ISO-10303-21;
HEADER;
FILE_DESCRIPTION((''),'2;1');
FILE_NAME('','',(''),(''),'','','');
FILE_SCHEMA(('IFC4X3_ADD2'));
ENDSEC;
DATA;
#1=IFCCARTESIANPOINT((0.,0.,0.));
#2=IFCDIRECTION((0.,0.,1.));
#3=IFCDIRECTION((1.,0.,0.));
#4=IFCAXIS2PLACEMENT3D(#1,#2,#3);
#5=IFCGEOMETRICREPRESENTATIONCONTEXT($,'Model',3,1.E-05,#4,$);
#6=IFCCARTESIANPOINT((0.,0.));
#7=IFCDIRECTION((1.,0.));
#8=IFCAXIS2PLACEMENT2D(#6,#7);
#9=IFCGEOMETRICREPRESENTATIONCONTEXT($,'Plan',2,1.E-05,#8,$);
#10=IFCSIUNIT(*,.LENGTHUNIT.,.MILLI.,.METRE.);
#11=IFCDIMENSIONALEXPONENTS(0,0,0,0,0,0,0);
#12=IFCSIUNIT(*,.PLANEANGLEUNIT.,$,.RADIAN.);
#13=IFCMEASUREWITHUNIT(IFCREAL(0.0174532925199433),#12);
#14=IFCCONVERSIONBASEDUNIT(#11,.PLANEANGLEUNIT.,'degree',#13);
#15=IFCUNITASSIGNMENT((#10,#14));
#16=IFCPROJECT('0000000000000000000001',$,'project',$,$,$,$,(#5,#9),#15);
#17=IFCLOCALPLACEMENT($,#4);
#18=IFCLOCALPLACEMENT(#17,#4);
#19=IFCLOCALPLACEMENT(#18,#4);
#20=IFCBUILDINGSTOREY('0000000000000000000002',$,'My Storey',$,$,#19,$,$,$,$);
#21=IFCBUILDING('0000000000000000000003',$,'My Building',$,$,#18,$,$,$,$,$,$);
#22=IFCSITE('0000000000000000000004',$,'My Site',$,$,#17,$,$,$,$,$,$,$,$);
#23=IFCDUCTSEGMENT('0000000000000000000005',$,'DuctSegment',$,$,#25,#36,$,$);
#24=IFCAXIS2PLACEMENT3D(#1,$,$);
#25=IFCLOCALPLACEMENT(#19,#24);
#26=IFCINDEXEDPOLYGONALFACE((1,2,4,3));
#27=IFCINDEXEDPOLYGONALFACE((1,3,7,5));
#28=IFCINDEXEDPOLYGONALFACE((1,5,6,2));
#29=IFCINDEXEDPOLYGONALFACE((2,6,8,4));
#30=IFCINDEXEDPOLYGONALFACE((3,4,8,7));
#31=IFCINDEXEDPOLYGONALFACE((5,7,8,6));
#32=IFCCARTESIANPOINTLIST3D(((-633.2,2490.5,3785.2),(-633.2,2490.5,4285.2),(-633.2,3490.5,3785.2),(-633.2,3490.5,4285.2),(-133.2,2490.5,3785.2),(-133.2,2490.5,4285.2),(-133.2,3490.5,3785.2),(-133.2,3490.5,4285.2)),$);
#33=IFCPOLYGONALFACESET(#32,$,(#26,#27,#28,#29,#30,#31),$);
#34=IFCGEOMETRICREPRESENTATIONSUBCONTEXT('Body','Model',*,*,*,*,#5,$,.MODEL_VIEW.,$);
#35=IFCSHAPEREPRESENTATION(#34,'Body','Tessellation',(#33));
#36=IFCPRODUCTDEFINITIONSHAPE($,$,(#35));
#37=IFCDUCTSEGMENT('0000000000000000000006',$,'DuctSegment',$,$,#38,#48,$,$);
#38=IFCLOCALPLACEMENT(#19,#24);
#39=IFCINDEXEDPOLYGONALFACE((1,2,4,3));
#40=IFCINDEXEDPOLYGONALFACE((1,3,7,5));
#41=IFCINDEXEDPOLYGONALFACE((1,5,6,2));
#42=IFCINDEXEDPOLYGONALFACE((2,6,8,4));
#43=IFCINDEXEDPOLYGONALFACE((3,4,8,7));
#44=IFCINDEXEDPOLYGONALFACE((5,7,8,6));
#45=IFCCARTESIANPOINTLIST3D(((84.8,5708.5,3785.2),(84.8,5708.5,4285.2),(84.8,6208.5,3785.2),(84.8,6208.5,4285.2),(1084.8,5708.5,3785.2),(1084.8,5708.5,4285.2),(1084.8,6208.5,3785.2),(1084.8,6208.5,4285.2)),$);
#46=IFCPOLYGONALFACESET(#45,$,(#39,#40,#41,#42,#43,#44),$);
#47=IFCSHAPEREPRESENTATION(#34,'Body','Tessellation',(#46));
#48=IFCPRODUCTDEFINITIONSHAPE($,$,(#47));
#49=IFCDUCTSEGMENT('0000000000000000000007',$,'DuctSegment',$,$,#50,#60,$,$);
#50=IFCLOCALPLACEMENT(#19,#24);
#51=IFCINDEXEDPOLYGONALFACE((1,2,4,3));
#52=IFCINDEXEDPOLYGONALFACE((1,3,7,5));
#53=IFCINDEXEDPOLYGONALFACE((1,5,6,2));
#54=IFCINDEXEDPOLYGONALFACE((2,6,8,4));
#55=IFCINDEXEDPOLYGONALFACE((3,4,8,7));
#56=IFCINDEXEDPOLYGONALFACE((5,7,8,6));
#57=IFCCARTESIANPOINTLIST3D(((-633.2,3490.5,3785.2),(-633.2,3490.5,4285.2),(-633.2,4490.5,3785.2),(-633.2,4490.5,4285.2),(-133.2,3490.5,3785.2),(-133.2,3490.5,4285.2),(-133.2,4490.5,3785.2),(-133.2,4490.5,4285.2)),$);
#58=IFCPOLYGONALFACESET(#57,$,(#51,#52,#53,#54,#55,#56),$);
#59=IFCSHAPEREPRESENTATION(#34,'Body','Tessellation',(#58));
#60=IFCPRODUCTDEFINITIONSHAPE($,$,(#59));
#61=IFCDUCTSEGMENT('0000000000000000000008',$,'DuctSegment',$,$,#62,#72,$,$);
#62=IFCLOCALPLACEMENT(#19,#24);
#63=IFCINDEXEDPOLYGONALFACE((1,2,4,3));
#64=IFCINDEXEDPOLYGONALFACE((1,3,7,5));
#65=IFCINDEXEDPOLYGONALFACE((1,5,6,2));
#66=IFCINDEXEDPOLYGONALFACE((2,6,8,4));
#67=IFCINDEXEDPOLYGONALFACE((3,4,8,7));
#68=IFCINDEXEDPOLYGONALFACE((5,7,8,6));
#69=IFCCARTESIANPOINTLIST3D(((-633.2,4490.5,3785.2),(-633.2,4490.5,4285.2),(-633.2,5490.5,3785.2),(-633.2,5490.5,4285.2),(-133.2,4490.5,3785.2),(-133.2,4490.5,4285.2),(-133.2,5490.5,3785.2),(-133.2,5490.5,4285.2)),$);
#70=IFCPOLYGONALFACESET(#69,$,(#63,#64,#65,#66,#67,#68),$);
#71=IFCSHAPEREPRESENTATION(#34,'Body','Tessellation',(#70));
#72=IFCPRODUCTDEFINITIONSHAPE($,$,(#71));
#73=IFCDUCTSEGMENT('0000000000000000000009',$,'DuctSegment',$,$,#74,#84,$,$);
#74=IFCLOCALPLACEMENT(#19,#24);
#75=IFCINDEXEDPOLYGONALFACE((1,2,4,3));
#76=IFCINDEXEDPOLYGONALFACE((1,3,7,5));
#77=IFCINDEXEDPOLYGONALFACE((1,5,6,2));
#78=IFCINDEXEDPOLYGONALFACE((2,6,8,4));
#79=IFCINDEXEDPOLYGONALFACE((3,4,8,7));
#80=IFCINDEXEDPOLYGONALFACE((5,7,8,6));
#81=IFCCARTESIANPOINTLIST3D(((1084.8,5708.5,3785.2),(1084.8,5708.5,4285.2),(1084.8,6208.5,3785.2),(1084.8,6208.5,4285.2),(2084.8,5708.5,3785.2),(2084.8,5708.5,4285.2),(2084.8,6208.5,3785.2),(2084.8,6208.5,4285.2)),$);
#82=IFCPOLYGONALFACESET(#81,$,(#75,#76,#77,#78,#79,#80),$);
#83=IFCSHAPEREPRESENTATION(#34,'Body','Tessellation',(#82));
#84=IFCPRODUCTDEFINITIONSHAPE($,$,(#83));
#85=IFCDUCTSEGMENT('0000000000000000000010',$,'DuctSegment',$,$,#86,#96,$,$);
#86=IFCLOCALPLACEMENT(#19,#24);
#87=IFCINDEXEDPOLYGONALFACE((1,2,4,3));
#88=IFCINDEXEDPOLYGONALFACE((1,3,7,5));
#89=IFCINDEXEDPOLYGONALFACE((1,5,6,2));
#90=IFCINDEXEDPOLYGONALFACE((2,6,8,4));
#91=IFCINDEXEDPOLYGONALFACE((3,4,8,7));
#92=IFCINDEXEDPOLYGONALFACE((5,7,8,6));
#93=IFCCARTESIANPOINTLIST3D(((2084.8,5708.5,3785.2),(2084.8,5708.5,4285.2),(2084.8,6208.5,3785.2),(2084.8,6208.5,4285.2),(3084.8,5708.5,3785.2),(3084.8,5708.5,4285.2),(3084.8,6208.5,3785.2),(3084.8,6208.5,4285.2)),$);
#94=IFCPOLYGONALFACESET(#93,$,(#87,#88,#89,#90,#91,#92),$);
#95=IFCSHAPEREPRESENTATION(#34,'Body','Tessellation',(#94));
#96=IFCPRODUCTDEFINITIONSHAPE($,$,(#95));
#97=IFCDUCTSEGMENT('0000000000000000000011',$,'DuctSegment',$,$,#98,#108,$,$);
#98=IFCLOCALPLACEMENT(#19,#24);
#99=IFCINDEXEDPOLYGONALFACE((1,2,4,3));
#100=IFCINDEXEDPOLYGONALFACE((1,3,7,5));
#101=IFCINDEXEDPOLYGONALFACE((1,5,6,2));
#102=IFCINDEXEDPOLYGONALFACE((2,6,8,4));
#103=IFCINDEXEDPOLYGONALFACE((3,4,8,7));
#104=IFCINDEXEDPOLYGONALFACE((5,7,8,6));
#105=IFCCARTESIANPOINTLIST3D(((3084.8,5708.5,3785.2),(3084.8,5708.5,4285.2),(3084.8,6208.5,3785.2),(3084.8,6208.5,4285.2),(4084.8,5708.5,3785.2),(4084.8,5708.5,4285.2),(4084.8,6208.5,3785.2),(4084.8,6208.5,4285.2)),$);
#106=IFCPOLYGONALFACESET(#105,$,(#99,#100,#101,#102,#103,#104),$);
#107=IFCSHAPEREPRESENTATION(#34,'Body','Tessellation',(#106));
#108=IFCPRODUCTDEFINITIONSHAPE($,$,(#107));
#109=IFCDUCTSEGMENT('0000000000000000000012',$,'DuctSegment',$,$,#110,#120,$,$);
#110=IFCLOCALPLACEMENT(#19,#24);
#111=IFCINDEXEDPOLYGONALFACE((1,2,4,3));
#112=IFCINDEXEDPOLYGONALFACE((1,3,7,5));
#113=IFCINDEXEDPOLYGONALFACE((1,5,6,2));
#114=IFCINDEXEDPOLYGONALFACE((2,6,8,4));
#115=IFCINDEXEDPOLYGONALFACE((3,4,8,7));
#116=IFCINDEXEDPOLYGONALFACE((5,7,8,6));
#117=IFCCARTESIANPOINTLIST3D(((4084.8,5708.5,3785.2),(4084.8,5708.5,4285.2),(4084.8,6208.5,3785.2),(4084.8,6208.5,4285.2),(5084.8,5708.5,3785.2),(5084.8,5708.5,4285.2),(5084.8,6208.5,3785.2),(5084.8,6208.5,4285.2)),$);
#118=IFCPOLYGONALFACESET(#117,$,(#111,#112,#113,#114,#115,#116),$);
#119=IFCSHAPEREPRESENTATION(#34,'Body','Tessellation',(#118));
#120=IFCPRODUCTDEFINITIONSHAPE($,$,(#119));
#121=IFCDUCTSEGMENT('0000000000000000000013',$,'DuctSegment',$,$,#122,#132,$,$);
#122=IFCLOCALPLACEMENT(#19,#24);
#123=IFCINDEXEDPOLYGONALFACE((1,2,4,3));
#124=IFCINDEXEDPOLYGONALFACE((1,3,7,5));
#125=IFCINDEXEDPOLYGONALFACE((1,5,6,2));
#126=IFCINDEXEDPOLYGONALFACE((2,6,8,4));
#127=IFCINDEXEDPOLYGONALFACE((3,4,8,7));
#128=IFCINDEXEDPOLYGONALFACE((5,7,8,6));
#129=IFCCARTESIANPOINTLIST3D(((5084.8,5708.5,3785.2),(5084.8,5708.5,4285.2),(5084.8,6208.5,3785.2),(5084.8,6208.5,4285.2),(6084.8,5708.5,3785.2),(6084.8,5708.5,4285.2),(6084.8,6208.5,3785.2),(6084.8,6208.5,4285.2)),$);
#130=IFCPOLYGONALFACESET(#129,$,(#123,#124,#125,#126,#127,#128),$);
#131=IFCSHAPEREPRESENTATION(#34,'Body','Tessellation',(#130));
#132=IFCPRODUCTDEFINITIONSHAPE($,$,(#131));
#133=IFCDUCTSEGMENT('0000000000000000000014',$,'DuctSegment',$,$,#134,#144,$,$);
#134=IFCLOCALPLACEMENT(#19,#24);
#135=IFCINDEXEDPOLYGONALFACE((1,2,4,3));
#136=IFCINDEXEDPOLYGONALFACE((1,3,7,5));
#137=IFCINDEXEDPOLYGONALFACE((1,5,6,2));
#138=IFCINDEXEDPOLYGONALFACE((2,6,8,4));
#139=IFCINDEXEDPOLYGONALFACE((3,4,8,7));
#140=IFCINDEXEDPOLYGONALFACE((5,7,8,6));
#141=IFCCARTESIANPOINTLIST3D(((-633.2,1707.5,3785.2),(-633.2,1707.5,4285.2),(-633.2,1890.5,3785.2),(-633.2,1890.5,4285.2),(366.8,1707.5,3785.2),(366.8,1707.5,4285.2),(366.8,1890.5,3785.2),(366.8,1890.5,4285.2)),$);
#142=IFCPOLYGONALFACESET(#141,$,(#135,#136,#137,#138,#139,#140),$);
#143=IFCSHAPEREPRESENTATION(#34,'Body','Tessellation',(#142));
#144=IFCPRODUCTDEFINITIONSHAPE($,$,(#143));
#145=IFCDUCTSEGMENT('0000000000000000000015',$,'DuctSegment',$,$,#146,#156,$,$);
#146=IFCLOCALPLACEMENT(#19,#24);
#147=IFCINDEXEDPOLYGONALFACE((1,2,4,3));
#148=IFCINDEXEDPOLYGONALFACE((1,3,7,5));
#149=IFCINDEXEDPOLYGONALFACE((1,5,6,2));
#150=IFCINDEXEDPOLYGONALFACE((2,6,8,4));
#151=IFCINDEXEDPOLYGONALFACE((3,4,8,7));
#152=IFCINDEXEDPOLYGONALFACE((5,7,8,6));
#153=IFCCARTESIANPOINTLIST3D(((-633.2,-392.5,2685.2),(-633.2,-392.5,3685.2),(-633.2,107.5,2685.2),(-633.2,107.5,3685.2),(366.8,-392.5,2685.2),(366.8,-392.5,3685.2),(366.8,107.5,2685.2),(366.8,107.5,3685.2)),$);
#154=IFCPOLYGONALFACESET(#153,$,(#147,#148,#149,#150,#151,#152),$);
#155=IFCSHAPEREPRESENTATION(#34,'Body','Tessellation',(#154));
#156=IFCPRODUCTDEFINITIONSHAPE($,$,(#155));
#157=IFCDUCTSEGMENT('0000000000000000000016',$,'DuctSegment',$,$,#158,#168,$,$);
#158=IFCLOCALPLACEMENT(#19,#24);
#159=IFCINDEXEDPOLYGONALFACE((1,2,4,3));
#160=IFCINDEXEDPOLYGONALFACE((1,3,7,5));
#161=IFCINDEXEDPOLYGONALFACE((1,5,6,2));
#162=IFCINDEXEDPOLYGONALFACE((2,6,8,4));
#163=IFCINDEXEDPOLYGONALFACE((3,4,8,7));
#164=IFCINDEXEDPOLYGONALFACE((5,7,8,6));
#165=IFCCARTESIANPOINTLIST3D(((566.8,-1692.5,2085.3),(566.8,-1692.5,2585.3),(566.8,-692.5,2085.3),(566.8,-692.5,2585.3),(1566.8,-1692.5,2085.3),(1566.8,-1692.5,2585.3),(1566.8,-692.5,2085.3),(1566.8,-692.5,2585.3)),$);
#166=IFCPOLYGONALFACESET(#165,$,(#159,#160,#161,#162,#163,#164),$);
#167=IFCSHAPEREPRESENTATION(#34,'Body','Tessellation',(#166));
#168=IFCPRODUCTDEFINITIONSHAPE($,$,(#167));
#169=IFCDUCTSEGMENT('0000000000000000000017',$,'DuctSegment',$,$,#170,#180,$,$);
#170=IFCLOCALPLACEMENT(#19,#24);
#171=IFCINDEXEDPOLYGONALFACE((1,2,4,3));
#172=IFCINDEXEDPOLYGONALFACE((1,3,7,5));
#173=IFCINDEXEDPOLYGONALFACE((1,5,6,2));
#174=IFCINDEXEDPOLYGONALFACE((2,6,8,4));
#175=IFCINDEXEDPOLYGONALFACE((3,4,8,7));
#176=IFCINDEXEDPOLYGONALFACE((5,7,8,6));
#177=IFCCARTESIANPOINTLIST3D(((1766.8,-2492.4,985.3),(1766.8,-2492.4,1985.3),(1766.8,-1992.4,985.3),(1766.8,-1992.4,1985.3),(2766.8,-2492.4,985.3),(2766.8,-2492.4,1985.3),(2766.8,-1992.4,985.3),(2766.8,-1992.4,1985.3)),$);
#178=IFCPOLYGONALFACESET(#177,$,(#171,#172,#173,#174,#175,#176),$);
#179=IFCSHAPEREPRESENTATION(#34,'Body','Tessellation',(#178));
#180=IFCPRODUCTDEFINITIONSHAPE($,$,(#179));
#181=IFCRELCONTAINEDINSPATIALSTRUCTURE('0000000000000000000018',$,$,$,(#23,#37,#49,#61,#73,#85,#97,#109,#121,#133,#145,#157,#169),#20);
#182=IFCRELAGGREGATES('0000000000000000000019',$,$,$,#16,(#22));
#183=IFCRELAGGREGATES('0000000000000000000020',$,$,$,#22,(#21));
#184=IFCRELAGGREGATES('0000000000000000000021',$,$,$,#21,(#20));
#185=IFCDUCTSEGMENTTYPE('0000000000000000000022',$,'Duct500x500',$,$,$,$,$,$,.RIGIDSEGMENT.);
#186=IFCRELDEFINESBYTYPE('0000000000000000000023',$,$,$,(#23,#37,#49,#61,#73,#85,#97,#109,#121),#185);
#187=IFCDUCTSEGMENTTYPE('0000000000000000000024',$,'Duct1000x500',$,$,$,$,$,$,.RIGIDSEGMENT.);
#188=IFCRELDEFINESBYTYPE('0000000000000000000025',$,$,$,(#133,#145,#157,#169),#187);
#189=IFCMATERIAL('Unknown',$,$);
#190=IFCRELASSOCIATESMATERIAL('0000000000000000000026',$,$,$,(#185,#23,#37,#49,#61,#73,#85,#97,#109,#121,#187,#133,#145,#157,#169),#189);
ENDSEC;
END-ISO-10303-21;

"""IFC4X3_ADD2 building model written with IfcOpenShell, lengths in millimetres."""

from ifc_helpers import new_model, entity, si_unit, converted_unit, frame, origin_with_axes, origin_2d_with_axis, place, context, subcontext, project, spatial, indexed_curve, rectangle, outline, extrude, material, material_profile, profile_set, profile_usage, type_object, element, save


model = new_model("IFC4X3_ADD2")

# Units and contexts
model_context = context("Model", 3, precision=1e-05, world=origin_with_axes())
plan_context = context("Plan", 2, precision=1e-05, world=origin_2d_with_axis())
body_context = subcontext(model_context, "Body", "Model", "MODEL_VIEW")
ifc_project = project(units=[si_unit("LENGTHUNIT", "METRE", prefix="MILLI"), converted_unit("PLANEANGLEUNIT", "degree", entity("IfcReal", 0.0174532925199433), si_unit("PLANEANGLEUNIT", "RADIAN"), dimensions=[0, 0, 0, 0, 0, 0, 0])], contexts=[model_context, plan_context])

# Site, building, storey
site_placement = place(None, origin_with_axes())
site = spatial("IfcSite", under=ifc_project, at=site_placement, Name="My Site")
building_placement = place(site_placement, origin_with_axes())
building = spatial("IfcBuilding", under=site, at=building_placement, Name="My Building")
storey_placement = place(building_placement, origin_with_axes())
storey = spatial("IfcBuildingStorey", under=building, at=storey_placement, Name="My Storey")

# Duct segments
ifc_material = material(Name="Unknown")
ifc_material_profile_1 = material_profile(ifc_material, outline(indexed_curve([(-250.0, 250.0), (250.0, 250.0), (250.0, -250.0), (-250.0, -250.0), (-250.0, 250.0)])))
ifc_profile_set_1 = profile_set([ifc_material_profile_1])
ifc_profile_usage_1 = profile_usage(ifc_profile_set_1, cardinal=5)
duct_segment_type_1 = type_object("IfcDuctSegmentType", Name="Duct500x500", PredefinedType="RIGIDSEGMENT", material=ifc_profile_set_1)
duct_segment_1_placement = place(storey_placement, frame((-383.2, 2490.5, 4035.2), z_axis=(0.0, 1.0, 0.0), x_axis=(-1.0, 0.0, 0.0)))
element("IfcDuctSegment", 1, at=duct_segment_1_placement, inside=storey, type_object=duct_segment_type_1, material=ifc_profile_usage_1, Name="DuctSegment", context=body_context, shape_type="SweptSolid", body=[
    extrude(outline(indexed_curve([(-250.0, 250.0), (250.0, 250.0), (250.0, -250.0), (-250.0, -250.0), (-250.0, 250.0)])), origin_with_axes(), (0.0, 0.0, 1.0), 1000.0),
])
ifc_profile_usage_2 = profile_usage(ifc_profile_set_1, cardinal=5)
duct_segment_2_placement = place(storey_placement, frame((1084.8, 5958.5, 4035.2), z_axis=(-1.0, 0.0, 0.0), x_axis=(0.0, -1.0, 0.0)))
element("IfcDuctSegment", 2, at=duct_segment_2_placement, inside=storey, type_object=duct_segment_type_1, material=ifc_profile_usage_2, Name="DuctSegment", context=body_context, shape_type="SweptSolid", body=[
    extrude(outline(indexed_curve([(-250.0, 250.0), (250.0, 250.0), (250.0, -250.0), (-250.0, -250.0), (-250.0, 250.0)])), origin_with_axes(), (0.0, 0.0, 1.0), 1000.0),
])
ifc_profile_usage_3 = profile_usage(ifc_profile_set_1, cardinal=5)
duct_segment_3_placement = place(storey_placement, frame((-383.2, 3490.5, 4035.2), z_axis=(0.0, 1.0, 0.0), x_axis=(-1.0, 0.0, 0.0)))
element("IfcDuctSegment", 3, at=duct_segment_3_placement, inside=storey, type_object=duct_segment_type_1, material=ifc_profile_usage_3, Name="DuctSegment", context=body_context, shape_type="SweptSolid", body=[
    extrude(outline(indexed_curve([(-250.0, 250.0), (250.0, 250.0), (250.0, -250.0), (-250.0, -250.0), (-250.0, 250.0)])), origin_with_axes(), (0.0, 0.0, 1.0), 1000.0),
])
ifc_profile_usage_4 = profile_usage(ifc_profile_set_1, cardinal=5)
duct_segment_4_placement = place(storey_placement, frame((-383.2, 4490.5, 4035.2), z_axis=(0.0, 1.0, 0.0), x_axis=(-1.0, 0.0, 0.0)))
element("IfcDuctSegment", 4, at=duct_segment_4_placement, inside=storey, type_object=duct_segment_type_1, material=ifc_profile_usage_4, Name="DuctSegment", context=body_context, shape_type="SweptSolid", body=[
    extrude(outline(indexed_curve([(-250.0, 250.0), (250.0, 250.0), (250.0, -250.0), (-250.0, -250.0), (-250.0, 250.0)])), origin_with_axes(), (0.0, 0.0, 1.0), 1000.0),
])
ifc_profile_usage_5 = profile_usage(ifc_profile_set_1, cardinal=5)
duct_segment_5_placement = place(storey_placement, frame((2084.8, 5958.5, 4035.2), z_axis=(-1.0, 0.0, 0.0), x_axis=(0.0, -1.0, 0.0)))
element("IfcDuctSegment", 5, at=duct_segment_5_placement, inside=storey, type_object=duct_segment_type_1, material=ifc_profile_usage_5, Name="DuctSegment", context=body_context, shape_type="SweptSolid", body=[
    extrude(outline(indexed_curve([(-250.0, 250.0), (250.0, 250.0), (250.0, -250.0), (-250.0, -250.0), (-250.0, 250.0)])), origin_with_axes(), (0.0, 0.0, 1.0), 1000.0),
])
ifc_profile_usage_6 = profile_usage(ifc_profile_set_1, cardinal=5)
duct_segment_6_placement = place(storey_placement, frame((3084.8, 5958.5, 4035.2), z_axis=(-1.0, 0.0, 0.0), x_axis=(0.0, -1.0, 0.0)))
element("IfcDuctSegment", 6, at=duct_segment_6_placement, inside=storey, type_object=duct_segment_type_1, material=ifc_profile_usage_6, Name="DuctSegment", context=body_context, shape_type="SweptSolid", body=[
    extrude(outline(indexed_curve([(-250.0, 250.0), (250.0, 250.0), (250.0, -250.0), (-250.0, -250.0), (-250.0, 250.0)])), origin_with_axes(), (0.0, 0.0, 1.0), 1000.0),
])
ifc_profile_usage_7 = profile_usage(ifc_profile_set_1, cardinal=5)
duct_segment_7_placement = place(storey_placement, frame((4084.8, 5958.5, 4035.2), z_axis=(-1.0, 0.0, 0.0), x_axis=(0.0, -1.0, 0.0)))
element("IfcDuctSegment", 7, at=duct_segment_7_placement, inside=storey, type_object=duct_segment_type_1, material=ifc_profile_usage_7, Name="DuctSegment", context=body_context, shape_type="SweptSolid", body=[
    extrude(outline(indexed_curve([(-250.0, 250.0), (250.0, 250.0), (250.0, -250.0), (-250.0, -250.0), (-250.0, 250.0)])), origin_with_axes(), (0.0, 0.0, 1.0), 1000.0),
])
ifc_profile_usage_8 = profile_usage(ifc_profile_set_1, cardinal=5)
duct_segment_8_placement = place(storey_placement, frame((5084.8, 5958.5, 4035.2), z_axis=(-1.0, 0.0, 0.0), x_axis=(0.0, -1.0, 0.0)))
element("IfcDuctSegment", 8, at=duct_segment_8_placement, inside=storey, type_object=duct_segment_type_1, material=ifc_profile_usage_8, Name="DuctSegment", context=body_context, shape_type="SweptSolid", body=[
    extrude(outline(indexed_curve([(-250.0, 250.0), (250.0, 250.0), (250.0, -250.0), (-250.0, -250.0), (-250.0, 250.0)])), origin_with_axes(), (0.0, 0.0, 1.0), 1000.0),
])
ifc_profile_usage_9 = profile_usage(ifc_profile_set_1, cardinal=5)
duct_segment_9_placement = place(storey_placement, frame((6084.8, 5958.5, 4035.2), z_axis=(-1.0, 0.0, 0.0), x_axis=(0.0, -1.0, 0.0)))
element("IfcDuctSegment", 9, at=duct_segment_9_placement, inside=storey, type_object=duct_segment_type_1, material=ifc_profile_usage_9, Name="DuctSegment", context=body_context, shape_type="SweptSolid", body=[
    extrude(outline(indexed_curve([(-250.0, 250.0), (250.0, 250.0), (250.0, -250.0), (-250.0, -250.0), (-250.0, 250.0)])), origin_with_axes(), (0.0, 0.0, 1.0), 1000.0),
])
ifc_material_profile_2 = material_profile(ifc_material, rectangle(XDim=1000.0, YDim=500.0))
ifc_profile_set_2 = profile_set([ifc_material_profile_2], Name="duct1000x500")
ifc_profile_usage_10 = profile_usage(ifc_profile_set_2, cardinal=5)
duct_segment_type_2 = type_object("IfcDuctSegmentType", Name="Duct1000x500", PredefinedType="RIGIDSEGMENT", material=ifc_profile_set_2)
duct_segment_10_placement = place(storey_placement, frame((-133.2, 1707.5, 4035.2), z_axis=(0.0, 1.0, 0.0), x_axis=(-1.0, 0.0, 0.0)))
element("IfcDuctSegment", 10, at=duct_segment_10_placement, inside=storey, type_object=duct_segment_type_2, material=ifc_profile_usage_10, Name="DuctSegment", context=body_context, shape_type="SweptSolid", body=[
    extrude(rectangle(XDim=1000.0, YDim=500.0), origin_with_axes(), (0.0, 0.0, 1.0), 183.0),
])
ifc_profile_usage_11 = profile_usage(ifc_profile_set_2, cardinal=5)
duct_segment_11_placement = place(storey_placement, frame((-133.2, -142.5, 3685.2), z_axis=(0.0, 0.0, -1.0), x_axis=(-1.0, 0.0, 0.0)))
element("IfcDuctSegment", 11, at=duct_segment_11_placement, inside=storey, type_object=duct_segment_type_2, material=ifc_profile_usage_11, Name="DuctSegment", context=body_context, shape_type="SweptSolid", body=[
    extrude(rectangle(XDim=1000.0, YDim=500.0), origin_with_axes(), (0.0, 0.0, 1.0), 1000.0),
])
ifc_profile_usage_12 = profile_usage(ifc_profile_set_2, cardinal=5)
duct_segment_12_placement = place(storey_placement, frame((566.8, -1192.5, 2335.3), z_axis=(1.0, 0.0, 0.0), x_axis=(0.0, 1.0, 0.0)))
element("IfcDuctSegment", 12, at=duct_segment_12_placement, inside=storey, type_object=duct_segment_type_2, material=ifc_profile_usage_12, Name="DuctSegment", context=body_context, shape_type="SweptSolid", body=[
    extrude(rectangle(XDim=1000.0, YDim=500.0), origin_with_axes(), (0.0, 0.0, 1.0), 1000.0),
])
ifc_profile_usage_13 = profile_usage(ifc_profile_set_2, cardinal=5)
duct_segment_13_placement = place(storey_placement, frame((2266.8, -2242.4, 1985.3), z_axis=(0.0, 0.0, -1.0), x_axis=(-1.0, 0.0, 0.0)))
element("IfcDuctSegment", 13, at=duct_segment_13_placement, inside=storey, type_object=duct_segment_type_2, material=ifc_profile_usage_13, Name="DuctSegment", context=body_context, shape_type="SweptSolid", body=[
    extrude(rectangle(XDim=1000.0, YDim=500.0), origin_with_axes(), (0.0, 0.0, 1.0), 1000.0),
])

save(model, "model.ifc")
